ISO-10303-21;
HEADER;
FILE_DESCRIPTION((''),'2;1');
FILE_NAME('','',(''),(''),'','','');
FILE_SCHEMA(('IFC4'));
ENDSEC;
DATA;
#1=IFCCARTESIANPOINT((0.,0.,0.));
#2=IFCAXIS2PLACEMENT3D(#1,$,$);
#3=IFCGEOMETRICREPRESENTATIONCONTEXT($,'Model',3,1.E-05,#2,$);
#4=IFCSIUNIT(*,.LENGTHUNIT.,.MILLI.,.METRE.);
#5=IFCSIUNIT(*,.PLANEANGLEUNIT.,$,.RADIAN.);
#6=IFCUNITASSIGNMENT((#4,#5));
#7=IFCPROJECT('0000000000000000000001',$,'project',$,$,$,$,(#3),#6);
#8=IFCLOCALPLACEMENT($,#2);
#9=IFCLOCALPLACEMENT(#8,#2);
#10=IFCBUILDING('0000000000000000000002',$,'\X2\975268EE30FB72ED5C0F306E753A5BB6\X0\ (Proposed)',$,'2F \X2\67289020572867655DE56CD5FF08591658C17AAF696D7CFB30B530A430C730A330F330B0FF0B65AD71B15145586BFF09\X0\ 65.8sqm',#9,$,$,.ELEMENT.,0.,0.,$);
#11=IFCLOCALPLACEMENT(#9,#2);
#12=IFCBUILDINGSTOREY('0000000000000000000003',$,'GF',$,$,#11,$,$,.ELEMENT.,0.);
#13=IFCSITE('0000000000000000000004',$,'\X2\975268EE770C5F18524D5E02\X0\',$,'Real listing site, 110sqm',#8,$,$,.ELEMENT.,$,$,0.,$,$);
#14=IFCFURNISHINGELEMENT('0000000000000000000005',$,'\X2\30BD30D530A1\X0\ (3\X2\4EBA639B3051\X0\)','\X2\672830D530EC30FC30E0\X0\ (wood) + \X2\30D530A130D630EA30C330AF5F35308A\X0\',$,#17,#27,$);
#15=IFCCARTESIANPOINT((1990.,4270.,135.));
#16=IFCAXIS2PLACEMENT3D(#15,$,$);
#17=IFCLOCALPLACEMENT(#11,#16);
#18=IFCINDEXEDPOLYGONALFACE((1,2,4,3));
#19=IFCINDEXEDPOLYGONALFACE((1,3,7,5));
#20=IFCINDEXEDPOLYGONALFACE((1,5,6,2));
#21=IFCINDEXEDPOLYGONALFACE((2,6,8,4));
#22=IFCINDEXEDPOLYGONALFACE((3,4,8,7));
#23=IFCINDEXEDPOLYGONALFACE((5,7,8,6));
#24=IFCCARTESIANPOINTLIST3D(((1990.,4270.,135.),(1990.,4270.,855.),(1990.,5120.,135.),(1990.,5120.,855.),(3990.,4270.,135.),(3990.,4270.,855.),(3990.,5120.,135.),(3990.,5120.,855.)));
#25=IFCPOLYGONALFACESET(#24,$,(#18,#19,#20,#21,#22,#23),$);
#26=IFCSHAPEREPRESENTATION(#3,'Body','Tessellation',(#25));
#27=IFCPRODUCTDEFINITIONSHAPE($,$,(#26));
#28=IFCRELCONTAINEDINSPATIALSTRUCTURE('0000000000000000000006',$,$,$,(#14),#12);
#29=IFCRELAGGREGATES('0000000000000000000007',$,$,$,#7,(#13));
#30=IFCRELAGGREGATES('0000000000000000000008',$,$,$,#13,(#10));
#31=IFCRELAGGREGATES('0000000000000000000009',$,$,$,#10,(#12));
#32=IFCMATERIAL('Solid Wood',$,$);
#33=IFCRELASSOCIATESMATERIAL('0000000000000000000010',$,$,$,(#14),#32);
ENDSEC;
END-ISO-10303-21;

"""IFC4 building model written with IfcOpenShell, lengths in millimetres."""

from ifc_helpers import new_model, si_unit, frame, frame_2d, origin, place, context, project, spatial, rectangle, extrude, material, element, save


model = new_model("IFC4")

# Units and contexts
model_context = context("Model", 3, precision=1e-05, world=origin())
ifc_project = project(units=[si_unit("LENGTHUNIT", "METRE", prefix="MILLI"), si_unit("PLANEANGLEUNIT", "RADIAN")], contexts=[model_context])

# Site, building, storey
site_placement = place(None, origin())
site = spatial("IfcSite", under=ifc_project, at=site_placement, Name="青森県弘前市", ObjectType="Real listing site, 110sqm", CompositionType="ELEMENT", RefElevation=0.0)
building_placement = place(site_placement, origin())
building = spatial("IfcBuilding", under=site, at=building_placement, Name="青森・狭小の町家 (Proposed)", ObjectType="2F 木造在来工法（外壁窯業系サイディング＋断熱充填） 65.8sqm", CompositionType="ELEMENT", ElevationOfRefHeight=0.0, ElevationOfTerrain=0.0)
storey_placement = place(building_placement, origin())
storey = spatial("IfcBuildingStorey", under=building, at=storey_placement, Name="GF", CompositionType="ELEMENT", Elevation=0.0)

# Shared definitions
ifc_material_1 = material(Name="Solid Wood")

# Furnishing element
furnishing_placement = place(storey_placement, frame((1990.0, 4270.0, 135.0)))
element("IfcFurnishingElement", 1, at=furnishing_placement, inside=storey, material=ifc_material_1, Name="ソファ (3人掛け)", Description="木フレーム (wood) + ファブリック張り", context=model_context, shape_type="SweptSolid", body=[
    extrude(rectangle(XDim=2000.0, YDim=850.0, at=frame_2d((1000.0, 425.0))), frame((1990.0, 4270.0, 135.0)), (0.0, 0.0, 1.0), 720.0),
])

save(model, "model.ifc")
